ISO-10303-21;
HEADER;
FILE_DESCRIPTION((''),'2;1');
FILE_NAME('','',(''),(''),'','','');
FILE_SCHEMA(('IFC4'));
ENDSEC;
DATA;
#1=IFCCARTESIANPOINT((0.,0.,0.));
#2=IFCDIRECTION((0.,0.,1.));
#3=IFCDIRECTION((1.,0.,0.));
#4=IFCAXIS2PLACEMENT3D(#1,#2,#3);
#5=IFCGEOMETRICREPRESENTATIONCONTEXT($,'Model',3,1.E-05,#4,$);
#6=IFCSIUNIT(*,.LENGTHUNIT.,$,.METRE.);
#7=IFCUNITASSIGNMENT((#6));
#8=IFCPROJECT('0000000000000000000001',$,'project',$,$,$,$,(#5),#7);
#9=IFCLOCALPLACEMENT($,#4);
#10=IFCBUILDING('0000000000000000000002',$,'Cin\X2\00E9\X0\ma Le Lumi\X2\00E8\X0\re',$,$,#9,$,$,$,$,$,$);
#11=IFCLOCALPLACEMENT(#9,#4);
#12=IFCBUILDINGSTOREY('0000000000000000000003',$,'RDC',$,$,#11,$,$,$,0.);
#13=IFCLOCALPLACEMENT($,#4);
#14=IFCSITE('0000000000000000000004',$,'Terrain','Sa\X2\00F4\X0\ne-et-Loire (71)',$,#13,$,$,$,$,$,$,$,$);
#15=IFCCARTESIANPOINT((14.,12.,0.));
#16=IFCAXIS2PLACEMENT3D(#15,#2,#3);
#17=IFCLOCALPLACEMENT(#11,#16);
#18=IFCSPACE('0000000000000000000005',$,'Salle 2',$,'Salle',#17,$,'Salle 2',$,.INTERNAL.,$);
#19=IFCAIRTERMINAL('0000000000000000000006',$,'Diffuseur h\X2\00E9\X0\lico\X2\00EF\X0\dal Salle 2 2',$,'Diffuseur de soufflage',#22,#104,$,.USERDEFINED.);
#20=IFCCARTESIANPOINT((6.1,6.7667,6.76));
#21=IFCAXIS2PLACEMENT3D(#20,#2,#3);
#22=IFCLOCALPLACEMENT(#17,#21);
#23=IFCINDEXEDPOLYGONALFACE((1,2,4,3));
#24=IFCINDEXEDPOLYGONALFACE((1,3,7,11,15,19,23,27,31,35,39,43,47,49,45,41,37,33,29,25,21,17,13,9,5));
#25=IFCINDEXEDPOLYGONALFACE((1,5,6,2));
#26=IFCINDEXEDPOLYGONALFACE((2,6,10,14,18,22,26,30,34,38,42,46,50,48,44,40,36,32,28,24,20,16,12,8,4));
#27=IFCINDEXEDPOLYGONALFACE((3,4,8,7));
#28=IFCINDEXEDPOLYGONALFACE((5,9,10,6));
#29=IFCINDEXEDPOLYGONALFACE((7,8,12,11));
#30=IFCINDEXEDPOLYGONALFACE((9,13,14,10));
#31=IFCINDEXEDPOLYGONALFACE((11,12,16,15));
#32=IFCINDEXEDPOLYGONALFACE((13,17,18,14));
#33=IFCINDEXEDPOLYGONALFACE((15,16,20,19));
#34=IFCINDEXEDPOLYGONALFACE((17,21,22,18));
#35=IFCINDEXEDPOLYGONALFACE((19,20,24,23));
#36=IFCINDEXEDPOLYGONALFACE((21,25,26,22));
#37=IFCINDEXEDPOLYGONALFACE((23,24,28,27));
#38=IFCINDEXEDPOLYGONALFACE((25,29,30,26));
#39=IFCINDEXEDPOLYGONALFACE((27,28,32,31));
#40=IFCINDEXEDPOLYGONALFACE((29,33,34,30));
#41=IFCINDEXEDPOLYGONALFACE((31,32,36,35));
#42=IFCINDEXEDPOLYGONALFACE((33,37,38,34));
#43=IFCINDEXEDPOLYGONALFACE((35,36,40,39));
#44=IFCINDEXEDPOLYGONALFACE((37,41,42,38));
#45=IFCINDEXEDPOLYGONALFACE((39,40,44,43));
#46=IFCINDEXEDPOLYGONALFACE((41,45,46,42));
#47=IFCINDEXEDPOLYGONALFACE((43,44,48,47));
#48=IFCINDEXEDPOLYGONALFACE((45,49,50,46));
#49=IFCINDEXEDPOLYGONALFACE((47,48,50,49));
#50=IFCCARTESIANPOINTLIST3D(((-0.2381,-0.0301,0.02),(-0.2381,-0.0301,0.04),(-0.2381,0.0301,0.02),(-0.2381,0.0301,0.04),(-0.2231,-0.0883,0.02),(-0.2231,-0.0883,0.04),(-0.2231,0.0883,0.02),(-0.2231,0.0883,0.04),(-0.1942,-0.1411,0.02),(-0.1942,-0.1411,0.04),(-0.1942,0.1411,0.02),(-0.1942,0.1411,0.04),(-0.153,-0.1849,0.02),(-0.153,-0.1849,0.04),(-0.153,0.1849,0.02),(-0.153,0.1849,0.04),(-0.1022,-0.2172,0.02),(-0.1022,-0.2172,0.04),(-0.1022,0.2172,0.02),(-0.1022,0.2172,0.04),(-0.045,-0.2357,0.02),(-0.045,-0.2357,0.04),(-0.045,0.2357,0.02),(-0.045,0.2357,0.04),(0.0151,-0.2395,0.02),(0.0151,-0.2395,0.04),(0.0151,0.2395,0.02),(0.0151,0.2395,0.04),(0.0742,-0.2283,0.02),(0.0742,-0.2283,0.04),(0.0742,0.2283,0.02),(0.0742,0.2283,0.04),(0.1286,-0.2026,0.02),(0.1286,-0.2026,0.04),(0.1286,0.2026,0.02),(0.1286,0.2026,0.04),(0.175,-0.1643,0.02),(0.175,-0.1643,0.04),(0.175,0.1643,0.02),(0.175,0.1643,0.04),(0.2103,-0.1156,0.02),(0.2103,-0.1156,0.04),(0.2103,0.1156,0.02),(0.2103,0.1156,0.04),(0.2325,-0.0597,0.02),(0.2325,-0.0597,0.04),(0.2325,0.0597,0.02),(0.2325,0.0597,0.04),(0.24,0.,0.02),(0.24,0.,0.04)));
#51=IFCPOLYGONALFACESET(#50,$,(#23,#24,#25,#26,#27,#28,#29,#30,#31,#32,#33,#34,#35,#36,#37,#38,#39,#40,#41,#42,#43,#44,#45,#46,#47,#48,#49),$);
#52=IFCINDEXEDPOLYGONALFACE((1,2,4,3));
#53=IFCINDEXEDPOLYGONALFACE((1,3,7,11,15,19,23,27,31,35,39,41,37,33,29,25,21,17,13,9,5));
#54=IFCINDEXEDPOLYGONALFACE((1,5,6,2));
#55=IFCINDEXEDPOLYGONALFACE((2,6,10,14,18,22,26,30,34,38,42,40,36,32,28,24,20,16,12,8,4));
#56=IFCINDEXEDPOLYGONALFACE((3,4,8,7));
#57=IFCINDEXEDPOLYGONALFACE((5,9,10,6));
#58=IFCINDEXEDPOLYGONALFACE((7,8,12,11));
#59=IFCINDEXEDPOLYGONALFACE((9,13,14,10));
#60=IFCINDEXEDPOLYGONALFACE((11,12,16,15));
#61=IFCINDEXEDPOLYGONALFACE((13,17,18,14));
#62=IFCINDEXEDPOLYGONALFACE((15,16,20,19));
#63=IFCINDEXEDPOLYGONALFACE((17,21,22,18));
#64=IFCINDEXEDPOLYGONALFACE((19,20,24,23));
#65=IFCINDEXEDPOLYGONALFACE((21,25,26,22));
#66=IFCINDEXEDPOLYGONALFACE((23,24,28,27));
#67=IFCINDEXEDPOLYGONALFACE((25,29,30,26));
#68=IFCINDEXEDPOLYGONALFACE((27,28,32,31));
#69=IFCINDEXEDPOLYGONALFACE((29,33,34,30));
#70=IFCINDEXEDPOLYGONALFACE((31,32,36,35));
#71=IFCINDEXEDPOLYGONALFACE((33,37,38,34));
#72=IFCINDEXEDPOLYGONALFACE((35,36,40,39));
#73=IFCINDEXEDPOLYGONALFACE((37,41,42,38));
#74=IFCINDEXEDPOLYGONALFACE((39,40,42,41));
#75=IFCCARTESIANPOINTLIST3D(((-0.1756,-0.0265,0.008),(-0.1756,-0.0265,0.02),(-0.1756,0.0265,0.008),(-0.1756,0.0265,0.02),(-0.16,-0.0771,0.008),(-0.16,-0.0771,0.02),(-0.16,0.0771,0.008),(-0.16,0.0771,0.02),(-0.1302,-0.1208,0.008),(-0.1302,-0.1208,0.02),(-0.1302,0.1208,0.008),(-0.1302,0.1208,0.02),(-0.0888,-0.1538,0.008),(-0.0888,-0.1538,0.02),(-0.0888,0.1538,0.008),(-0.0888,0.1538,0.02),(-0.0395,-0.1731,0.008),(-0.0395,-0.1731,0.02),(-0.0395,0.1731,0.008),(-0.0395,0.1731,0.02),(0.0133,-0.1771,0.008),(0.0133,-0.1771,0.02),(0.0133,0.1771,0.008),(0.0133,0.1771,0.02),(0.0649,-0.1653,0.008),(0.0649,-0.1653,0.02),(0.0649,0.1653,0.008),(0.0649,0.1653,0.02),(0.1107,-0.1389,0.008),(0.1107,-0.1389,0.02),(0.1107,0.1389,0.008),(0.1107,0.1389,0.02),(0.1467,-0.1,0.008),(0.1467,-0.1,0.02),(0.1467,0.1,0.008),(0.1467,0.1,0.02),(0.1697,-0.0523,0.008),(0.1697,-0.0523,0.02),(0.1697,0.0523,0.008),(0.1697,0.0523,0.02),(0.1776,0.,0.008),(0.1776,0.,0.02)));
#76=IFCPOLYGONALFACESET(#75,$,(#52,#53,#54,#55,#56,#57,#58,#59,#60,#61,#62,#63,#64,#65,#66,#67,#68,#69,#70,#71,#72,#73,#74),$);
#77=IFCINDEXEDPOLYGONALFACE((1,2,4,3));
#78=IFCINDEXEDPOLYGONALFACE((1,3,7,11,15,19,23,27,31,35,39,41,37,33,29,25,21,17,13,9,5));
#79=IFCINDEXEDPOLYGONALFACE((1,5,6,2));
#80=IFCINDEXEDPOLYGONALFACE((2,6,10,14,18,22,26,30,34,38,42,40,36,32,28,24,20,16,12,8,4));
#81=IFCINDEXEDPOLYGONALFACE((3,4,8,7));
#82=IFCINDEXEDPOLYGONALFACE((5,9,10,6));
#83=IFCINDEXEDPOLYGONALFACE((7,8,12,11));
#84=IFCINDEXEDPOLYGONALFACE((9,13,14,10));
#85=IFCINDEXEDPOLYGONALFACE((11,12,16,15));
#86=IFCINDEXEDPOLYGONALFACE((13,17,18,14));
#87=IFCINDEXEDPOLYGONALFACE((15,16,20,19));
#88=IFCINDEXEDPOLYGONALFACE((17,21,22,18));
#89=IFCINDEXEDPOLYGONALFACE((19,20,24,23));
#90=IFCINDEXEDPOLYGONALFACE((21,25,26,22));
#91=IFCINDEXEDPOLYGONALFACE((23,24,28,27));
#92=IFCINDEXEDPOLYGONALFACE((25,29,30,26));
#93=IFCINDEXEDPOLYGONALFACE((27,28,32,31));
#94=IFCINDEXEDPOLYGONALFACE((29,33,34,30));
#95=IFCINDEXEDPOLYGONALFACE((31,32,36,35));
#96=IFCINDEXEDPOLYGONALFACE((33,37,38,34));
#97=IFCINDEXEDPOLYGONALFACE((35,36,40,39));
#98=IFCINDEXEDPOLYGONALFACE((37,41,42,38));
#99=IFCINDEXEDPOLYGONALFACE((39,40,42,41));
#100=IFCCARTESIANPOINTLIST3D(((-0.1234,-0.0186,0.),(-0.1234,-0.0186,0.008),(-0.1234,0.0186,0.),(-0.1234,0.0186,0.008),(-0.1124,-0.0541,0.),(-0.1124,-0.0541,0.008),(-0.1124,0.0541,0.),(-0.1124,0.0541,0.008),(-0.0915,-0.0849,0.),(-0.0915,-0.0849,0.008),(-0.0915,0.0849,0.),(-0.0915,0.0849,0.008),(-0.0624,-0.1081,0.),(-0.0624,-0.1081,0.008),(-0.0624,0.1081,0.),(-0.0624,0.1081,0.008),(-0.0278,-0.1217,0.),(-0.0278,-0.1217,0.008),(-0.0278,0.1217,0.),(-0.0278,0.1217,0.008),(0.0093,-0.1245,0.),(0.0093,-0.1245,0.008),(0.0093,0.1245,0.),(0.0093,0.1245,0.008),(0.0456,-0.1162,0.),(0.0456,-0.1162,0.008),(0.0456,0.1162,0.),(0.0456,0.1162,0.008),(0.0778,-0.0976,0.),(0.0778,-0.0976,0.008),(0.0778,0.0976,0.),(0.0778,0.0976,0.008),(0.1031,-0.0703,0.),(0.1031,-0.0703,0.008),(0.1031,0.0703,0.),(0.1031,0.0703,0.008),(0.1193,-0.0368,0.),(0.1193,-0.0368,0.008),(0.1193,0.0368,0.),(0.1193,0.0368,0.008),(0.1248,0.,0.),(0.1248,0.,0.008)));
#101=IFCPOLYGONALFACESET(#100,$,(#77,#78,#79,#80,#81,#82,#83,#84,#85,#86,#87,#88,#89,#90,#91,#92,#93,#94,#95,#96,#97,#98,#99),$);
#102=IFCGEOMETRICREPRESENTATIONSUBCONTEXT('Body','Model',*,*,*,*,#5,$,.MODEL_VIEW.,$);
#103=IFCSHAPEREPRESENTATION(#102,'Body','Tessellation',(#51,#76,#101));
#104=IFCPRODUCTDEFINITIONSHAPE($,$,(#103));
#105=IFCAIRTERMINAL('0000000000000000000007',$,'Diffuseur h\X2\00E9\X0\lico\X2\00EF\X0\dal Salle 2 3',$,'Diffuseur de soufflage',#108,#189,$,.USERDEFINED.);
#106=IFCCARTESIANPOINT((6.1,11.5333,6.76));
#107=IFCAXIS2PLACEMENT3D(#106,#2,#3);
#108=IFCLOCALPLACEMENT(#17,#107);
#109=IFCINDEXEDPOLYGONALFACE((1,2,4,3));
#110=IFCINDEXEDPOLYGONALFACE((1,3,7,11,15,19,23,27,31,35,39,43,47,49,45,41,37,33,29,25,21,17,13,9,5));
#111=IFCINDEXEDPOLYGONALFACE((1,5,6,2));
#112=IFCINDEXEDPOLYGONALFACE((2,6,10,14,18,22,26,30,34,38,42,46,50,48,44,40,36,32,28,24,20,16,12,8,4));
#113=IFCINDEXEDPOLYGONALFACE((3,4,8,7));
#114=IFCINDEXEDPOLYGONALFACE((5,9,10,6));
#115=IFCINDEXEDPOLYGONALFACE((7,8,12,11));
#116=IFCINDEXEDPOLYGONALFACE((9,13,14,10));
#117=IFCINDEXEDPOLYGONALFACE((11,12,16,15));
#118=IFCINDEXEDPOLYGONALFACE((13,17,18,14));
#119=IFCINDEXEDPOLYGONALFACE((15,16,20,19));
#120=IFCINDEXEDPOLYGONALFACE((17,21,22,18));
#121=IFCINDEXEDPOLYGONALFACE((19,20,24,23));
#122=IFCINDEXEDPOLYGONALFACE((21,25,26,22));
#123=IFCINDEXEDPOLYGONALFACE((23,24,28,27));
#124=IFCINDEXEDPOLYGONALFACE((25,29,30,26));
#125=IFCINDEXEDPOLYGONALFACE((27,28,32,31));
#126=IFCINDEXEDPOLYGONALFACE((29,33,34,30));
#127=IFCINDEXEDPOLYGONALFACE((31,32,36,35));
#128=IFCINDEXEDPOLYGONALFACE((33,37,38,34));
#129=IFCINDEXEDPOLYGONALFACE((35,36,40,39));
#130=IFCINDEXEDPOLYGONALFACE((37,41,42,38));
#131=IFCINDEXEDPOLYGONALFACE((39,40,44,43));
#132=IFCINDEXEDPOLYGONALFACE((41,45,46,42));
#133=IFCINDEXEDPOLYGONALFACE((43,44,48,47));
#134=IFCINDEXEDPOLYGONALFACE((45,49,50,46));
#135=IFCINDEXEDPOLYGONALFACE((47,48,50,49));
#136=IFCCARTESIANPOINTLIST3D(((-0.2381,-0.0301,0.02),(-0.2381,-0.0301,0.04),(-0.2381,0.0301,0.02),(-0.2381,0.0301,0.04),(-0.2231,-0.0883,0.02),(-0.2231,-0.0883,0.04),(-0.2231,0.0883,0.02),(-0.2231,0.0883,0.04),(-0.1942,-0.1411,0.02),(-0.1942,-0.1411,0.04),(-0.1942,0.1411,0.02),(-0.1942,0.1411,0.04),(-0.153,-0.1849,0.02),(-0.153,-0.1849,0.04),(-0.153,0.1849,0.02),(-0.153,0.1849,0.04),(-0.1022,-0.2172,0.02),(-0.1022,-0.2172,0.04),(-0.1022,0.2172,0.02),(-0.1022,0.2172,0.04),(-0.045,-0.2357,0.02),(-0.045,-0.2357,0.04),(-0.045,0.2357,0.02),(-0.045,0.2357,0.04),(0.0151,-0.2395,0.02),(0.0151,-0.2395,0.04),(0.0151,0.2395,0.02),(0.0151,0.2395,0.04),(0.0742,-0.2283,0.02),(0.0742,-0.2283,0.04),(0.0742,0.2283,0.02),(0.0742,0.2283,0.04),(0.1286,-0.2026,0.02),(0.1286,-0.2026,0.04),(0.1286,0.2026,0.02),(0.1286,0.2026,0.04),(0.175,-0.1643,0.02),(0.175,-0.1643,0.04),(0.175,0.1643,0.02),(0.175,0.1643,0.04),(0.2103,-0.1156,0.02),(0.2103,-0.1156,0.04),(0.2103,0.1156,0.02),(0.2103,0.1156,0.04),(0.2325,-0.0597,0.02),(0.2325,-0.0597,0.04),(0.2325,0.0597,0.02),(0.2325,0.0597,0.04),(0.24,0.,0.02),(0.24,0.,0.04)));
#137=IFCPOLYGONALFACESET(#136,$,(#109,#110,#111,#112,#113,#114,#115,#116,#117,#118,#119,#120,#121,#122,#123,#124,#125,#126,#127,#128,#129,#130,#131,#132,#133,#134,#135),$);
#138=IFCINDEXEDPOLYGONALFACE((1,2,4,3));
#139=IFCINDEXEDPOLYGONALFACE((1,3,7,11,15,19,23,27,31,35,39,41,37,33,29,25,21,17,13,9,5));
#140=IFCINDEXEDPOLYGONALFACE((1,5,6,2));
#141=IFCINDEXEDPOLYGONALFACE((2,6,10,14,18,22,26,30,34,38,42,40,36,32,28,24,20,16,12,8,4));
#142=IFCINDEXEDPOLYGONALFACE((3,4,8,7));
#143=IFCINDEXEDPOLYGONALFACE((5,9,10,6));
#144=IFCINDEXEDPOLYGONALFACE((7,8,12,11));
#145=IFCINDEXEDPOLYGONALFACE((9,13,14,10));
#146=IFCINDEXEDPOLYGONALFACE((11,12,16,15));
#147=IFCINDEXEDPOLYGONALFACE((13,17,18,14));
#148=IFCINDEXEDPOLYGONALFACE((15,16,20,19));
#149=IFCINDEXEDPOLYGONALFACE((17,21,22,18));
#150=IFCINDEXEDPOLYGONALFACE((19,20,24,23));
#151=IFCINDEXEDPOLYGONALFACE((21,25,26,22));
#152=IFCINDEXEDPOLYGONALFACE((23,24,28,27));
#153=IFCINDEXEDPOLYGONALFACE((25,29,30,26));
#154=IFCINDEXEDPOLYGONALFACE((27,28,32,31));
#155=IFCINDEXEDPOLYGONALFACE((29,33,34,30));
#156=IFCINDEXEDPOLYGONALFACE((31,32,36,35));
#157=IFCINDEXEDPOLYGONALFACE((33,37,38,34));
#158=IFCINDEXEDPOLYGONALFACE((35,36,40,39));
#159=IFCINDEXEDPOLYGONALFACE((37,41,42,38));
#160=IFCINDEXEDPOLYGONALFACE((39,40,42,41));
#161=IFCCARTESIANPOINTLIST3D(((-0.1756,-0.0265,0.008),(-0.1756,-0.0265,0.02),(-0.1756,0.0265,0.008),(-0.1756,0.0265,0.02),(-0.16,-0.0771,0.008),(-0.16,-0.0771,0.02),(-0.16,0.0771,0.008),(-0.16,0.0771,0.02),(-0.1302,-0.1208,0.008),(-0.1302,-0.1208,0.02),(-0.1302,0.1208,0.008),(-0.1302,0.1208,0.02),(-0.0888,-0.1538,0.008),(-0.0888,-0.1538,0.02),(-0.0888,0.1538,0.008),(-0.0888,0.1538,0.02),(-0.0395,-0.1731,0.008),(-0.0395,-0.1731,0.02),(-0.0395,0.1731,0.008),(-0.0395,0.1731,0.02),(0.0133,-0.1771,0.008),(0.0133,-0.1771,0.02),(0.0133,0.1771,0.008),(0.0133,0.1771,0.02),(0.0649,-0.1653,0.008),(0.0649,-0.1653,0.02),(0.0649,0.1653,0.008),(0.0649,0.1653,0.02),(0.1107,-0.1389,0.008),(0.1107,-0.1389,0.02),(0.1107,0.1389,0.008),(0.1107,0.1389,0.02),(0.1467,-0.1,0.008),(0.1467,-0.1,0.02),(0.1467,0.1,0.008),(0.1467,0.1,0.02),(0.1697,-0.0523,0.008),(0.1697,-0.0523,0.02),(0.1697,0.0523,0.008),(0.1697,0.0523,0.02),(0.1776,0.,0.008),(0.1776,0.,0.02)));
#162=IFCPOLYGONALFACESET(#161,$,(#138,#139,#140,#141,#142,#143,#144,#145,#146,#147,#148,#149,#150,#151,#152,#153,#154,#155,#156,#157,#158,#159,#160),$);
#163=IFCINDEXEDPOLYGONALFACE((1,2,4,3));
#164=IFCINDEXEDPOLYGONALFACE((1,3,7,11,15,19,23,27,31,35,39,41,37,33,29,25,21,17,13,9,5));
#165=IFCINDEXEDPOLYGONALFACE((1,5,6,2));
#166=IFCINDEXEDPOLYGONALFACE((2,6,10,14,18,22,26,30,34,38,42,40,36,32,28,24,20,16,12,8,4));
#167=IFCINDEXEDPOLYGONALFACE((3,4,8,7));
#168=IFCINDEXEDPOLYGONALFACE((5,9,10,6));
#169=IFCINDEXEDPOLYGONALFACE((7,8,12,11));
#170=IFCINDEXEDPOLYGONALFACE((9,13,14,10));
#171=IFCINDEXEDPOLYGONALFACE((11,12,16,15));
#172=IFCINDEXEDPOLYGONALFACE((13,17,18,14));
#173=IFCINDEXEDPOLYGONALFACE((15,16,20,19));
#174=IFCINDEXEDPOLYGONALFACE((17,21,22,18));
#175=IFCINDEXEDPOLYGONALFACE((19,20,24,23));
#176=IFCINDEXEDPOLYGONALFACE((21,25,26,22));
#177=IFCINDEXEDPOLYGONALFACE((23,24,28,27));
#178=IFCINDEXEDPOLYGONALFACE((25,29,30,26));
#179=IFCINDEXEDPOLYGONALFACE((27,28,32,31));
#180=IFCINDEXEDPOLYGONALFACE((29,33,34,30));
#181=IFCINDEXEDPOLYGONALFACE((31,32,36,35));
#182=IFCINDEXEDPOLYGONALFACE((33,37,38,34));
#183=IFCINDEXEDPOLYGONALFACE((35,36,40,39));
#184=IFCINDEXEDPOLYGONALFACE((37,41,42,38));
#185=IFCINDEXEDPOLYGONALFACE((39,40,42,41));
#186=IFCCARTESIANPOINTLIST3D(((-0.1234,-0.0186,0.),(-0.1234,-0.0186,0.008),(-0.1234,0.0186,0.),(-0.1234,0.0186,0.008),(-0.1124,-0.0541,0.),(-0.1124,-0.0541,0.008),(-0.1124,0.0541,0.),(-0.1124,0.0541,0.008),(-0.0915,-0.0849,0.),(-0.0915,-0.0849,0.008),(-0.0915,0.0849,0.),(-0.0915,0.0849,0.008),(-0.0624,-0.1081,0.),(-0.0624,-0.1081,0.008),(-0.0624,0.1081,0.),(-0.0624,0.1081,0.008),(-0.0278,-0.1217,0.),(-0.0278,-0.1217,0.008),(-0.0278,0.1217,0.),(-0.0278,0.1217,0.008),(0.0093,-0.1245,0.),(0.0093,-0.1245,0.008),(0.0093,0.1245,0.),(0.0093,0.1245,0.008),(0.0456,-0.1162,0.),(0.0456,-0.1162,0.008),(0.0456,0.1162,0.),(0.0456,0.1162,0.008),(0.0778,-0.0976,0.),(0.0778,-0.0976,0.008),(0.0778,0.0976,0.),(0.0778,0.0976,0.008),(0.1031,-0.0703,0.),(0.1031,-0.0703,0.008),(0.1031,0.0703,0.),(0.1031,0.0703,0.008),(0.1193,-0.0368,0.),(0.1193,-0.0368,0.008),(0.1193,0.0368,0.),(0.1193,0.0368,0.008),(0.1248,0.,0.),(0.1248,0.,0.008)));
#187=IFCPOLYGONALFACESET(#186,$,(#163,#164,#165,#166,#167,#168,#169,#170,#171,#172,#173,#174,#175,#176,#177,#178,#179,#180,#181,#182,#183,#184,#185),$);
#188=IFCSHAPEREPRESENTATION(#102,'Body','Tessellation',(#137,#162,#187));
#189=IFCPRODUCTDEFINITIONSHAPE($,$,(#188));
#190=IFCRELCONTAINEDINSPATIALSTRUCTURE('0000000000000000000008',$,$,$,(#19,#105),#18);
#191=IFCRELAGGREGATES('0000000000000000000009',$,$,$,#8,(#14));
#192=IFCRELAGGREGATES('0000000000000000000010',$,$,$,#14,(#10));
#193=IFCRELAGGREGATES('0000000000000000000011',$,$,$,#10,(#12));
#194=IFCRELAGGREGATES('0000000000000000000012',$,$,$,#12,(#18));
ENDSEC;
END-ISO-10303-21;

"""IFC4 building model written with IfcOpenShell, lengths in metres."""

from ifc_helpers import new_model, si_unit, frame, origin_with_axes, place, context, subcontext, project, spatial, circle, extrude, element, save


model = new_model("IFC4")

# Units and contexts
model_context = context("Model", 3, precision=1e-05, world=origin_with_axes())
body_context = subcontext(model_context, "Body", "Model", "MODEL_VIEW")
ifc_project = project(units=[si_unit("LENGTHUNIT", "METRE")], contexts=[model_context])

# Site, building, storey
site_placement = place(None, origin_with_axes())
site = spatial("IfcSite", under=ifc_project, at=site_placement, Name="Terrain", Description="Saône-et-Loire (71)")
building_placement = place(None, origin_with_axes())
building = spatial("IfcBuilding", under=site, at=building_placement, Name="Cinéma Le Lumière")
storey_placement = place(building_placement, origin_with_axes())
storey = spatial("IfcBuildingStorey", under=building, at=storey_placement, Name="RDC", Elevation=0.0)

# Shared definitions
space_1_placement = place(storey_placement, frame((14.0, 12.0, 0.0), z_axis=(0.0, 0.0, 1.0), x_axis=(1.0, 0.0, 0.0)))
space_1 = spatial("IfcSpace", under=storey, at=space_1_placement, Name="Salle 2", ObjectType="Salle", LongName="Salle 2", PredefinedType="INTERNAL")

# Air terminals
for number, where, z_axis, x_axis, name in (
    (1, (6.1, 6.7667, 6.76), (0.0, 0.0, 1.0), (1.0, 0.0, 0.0), "Diffuseur hélicoïdal Salle 2 2"),
    (2, (6.1, 11.5333, 6.76), (0.0, 0.0, 1.0), (1.0, 0.0, 0.0), "Diffuseur hélicoïdal Salle 2 3"),
):
    element("IfcAirTerminal", number, at=place(space_1_placement, frame(where, z_axis=z_axis, x_axis=x_axis)), inside=space_1, Name=name, ObjectType="Diffuseur de soufflage", PredefinedType="USERDEFINED", context=body_context, shape_type="SweptSolid", body=[
        extrude(circle(Radius=0.24), frame((0.0, 0.0, 0.02), z_axis=(0.0, 0.0, 1.0), x_axis=(1.0, 0.0, 0.0)), (0.0, 0.0, 1.0), 0.02),
        extrude(circle(Radius=0.1776), frame((0.0, 0.0, 0.008), z_axis=(0.0, 0.0, 1.0), x_axis=(1.0, 0.0, 0.0)), (0.0, 0.0, 1.0), 0.012),
        extrude(circle(Radius=0.1248), origin_with_axes(), (0.0, 0.0, 1.0), 0.008),
    ])

save(model, "model.ifc")
